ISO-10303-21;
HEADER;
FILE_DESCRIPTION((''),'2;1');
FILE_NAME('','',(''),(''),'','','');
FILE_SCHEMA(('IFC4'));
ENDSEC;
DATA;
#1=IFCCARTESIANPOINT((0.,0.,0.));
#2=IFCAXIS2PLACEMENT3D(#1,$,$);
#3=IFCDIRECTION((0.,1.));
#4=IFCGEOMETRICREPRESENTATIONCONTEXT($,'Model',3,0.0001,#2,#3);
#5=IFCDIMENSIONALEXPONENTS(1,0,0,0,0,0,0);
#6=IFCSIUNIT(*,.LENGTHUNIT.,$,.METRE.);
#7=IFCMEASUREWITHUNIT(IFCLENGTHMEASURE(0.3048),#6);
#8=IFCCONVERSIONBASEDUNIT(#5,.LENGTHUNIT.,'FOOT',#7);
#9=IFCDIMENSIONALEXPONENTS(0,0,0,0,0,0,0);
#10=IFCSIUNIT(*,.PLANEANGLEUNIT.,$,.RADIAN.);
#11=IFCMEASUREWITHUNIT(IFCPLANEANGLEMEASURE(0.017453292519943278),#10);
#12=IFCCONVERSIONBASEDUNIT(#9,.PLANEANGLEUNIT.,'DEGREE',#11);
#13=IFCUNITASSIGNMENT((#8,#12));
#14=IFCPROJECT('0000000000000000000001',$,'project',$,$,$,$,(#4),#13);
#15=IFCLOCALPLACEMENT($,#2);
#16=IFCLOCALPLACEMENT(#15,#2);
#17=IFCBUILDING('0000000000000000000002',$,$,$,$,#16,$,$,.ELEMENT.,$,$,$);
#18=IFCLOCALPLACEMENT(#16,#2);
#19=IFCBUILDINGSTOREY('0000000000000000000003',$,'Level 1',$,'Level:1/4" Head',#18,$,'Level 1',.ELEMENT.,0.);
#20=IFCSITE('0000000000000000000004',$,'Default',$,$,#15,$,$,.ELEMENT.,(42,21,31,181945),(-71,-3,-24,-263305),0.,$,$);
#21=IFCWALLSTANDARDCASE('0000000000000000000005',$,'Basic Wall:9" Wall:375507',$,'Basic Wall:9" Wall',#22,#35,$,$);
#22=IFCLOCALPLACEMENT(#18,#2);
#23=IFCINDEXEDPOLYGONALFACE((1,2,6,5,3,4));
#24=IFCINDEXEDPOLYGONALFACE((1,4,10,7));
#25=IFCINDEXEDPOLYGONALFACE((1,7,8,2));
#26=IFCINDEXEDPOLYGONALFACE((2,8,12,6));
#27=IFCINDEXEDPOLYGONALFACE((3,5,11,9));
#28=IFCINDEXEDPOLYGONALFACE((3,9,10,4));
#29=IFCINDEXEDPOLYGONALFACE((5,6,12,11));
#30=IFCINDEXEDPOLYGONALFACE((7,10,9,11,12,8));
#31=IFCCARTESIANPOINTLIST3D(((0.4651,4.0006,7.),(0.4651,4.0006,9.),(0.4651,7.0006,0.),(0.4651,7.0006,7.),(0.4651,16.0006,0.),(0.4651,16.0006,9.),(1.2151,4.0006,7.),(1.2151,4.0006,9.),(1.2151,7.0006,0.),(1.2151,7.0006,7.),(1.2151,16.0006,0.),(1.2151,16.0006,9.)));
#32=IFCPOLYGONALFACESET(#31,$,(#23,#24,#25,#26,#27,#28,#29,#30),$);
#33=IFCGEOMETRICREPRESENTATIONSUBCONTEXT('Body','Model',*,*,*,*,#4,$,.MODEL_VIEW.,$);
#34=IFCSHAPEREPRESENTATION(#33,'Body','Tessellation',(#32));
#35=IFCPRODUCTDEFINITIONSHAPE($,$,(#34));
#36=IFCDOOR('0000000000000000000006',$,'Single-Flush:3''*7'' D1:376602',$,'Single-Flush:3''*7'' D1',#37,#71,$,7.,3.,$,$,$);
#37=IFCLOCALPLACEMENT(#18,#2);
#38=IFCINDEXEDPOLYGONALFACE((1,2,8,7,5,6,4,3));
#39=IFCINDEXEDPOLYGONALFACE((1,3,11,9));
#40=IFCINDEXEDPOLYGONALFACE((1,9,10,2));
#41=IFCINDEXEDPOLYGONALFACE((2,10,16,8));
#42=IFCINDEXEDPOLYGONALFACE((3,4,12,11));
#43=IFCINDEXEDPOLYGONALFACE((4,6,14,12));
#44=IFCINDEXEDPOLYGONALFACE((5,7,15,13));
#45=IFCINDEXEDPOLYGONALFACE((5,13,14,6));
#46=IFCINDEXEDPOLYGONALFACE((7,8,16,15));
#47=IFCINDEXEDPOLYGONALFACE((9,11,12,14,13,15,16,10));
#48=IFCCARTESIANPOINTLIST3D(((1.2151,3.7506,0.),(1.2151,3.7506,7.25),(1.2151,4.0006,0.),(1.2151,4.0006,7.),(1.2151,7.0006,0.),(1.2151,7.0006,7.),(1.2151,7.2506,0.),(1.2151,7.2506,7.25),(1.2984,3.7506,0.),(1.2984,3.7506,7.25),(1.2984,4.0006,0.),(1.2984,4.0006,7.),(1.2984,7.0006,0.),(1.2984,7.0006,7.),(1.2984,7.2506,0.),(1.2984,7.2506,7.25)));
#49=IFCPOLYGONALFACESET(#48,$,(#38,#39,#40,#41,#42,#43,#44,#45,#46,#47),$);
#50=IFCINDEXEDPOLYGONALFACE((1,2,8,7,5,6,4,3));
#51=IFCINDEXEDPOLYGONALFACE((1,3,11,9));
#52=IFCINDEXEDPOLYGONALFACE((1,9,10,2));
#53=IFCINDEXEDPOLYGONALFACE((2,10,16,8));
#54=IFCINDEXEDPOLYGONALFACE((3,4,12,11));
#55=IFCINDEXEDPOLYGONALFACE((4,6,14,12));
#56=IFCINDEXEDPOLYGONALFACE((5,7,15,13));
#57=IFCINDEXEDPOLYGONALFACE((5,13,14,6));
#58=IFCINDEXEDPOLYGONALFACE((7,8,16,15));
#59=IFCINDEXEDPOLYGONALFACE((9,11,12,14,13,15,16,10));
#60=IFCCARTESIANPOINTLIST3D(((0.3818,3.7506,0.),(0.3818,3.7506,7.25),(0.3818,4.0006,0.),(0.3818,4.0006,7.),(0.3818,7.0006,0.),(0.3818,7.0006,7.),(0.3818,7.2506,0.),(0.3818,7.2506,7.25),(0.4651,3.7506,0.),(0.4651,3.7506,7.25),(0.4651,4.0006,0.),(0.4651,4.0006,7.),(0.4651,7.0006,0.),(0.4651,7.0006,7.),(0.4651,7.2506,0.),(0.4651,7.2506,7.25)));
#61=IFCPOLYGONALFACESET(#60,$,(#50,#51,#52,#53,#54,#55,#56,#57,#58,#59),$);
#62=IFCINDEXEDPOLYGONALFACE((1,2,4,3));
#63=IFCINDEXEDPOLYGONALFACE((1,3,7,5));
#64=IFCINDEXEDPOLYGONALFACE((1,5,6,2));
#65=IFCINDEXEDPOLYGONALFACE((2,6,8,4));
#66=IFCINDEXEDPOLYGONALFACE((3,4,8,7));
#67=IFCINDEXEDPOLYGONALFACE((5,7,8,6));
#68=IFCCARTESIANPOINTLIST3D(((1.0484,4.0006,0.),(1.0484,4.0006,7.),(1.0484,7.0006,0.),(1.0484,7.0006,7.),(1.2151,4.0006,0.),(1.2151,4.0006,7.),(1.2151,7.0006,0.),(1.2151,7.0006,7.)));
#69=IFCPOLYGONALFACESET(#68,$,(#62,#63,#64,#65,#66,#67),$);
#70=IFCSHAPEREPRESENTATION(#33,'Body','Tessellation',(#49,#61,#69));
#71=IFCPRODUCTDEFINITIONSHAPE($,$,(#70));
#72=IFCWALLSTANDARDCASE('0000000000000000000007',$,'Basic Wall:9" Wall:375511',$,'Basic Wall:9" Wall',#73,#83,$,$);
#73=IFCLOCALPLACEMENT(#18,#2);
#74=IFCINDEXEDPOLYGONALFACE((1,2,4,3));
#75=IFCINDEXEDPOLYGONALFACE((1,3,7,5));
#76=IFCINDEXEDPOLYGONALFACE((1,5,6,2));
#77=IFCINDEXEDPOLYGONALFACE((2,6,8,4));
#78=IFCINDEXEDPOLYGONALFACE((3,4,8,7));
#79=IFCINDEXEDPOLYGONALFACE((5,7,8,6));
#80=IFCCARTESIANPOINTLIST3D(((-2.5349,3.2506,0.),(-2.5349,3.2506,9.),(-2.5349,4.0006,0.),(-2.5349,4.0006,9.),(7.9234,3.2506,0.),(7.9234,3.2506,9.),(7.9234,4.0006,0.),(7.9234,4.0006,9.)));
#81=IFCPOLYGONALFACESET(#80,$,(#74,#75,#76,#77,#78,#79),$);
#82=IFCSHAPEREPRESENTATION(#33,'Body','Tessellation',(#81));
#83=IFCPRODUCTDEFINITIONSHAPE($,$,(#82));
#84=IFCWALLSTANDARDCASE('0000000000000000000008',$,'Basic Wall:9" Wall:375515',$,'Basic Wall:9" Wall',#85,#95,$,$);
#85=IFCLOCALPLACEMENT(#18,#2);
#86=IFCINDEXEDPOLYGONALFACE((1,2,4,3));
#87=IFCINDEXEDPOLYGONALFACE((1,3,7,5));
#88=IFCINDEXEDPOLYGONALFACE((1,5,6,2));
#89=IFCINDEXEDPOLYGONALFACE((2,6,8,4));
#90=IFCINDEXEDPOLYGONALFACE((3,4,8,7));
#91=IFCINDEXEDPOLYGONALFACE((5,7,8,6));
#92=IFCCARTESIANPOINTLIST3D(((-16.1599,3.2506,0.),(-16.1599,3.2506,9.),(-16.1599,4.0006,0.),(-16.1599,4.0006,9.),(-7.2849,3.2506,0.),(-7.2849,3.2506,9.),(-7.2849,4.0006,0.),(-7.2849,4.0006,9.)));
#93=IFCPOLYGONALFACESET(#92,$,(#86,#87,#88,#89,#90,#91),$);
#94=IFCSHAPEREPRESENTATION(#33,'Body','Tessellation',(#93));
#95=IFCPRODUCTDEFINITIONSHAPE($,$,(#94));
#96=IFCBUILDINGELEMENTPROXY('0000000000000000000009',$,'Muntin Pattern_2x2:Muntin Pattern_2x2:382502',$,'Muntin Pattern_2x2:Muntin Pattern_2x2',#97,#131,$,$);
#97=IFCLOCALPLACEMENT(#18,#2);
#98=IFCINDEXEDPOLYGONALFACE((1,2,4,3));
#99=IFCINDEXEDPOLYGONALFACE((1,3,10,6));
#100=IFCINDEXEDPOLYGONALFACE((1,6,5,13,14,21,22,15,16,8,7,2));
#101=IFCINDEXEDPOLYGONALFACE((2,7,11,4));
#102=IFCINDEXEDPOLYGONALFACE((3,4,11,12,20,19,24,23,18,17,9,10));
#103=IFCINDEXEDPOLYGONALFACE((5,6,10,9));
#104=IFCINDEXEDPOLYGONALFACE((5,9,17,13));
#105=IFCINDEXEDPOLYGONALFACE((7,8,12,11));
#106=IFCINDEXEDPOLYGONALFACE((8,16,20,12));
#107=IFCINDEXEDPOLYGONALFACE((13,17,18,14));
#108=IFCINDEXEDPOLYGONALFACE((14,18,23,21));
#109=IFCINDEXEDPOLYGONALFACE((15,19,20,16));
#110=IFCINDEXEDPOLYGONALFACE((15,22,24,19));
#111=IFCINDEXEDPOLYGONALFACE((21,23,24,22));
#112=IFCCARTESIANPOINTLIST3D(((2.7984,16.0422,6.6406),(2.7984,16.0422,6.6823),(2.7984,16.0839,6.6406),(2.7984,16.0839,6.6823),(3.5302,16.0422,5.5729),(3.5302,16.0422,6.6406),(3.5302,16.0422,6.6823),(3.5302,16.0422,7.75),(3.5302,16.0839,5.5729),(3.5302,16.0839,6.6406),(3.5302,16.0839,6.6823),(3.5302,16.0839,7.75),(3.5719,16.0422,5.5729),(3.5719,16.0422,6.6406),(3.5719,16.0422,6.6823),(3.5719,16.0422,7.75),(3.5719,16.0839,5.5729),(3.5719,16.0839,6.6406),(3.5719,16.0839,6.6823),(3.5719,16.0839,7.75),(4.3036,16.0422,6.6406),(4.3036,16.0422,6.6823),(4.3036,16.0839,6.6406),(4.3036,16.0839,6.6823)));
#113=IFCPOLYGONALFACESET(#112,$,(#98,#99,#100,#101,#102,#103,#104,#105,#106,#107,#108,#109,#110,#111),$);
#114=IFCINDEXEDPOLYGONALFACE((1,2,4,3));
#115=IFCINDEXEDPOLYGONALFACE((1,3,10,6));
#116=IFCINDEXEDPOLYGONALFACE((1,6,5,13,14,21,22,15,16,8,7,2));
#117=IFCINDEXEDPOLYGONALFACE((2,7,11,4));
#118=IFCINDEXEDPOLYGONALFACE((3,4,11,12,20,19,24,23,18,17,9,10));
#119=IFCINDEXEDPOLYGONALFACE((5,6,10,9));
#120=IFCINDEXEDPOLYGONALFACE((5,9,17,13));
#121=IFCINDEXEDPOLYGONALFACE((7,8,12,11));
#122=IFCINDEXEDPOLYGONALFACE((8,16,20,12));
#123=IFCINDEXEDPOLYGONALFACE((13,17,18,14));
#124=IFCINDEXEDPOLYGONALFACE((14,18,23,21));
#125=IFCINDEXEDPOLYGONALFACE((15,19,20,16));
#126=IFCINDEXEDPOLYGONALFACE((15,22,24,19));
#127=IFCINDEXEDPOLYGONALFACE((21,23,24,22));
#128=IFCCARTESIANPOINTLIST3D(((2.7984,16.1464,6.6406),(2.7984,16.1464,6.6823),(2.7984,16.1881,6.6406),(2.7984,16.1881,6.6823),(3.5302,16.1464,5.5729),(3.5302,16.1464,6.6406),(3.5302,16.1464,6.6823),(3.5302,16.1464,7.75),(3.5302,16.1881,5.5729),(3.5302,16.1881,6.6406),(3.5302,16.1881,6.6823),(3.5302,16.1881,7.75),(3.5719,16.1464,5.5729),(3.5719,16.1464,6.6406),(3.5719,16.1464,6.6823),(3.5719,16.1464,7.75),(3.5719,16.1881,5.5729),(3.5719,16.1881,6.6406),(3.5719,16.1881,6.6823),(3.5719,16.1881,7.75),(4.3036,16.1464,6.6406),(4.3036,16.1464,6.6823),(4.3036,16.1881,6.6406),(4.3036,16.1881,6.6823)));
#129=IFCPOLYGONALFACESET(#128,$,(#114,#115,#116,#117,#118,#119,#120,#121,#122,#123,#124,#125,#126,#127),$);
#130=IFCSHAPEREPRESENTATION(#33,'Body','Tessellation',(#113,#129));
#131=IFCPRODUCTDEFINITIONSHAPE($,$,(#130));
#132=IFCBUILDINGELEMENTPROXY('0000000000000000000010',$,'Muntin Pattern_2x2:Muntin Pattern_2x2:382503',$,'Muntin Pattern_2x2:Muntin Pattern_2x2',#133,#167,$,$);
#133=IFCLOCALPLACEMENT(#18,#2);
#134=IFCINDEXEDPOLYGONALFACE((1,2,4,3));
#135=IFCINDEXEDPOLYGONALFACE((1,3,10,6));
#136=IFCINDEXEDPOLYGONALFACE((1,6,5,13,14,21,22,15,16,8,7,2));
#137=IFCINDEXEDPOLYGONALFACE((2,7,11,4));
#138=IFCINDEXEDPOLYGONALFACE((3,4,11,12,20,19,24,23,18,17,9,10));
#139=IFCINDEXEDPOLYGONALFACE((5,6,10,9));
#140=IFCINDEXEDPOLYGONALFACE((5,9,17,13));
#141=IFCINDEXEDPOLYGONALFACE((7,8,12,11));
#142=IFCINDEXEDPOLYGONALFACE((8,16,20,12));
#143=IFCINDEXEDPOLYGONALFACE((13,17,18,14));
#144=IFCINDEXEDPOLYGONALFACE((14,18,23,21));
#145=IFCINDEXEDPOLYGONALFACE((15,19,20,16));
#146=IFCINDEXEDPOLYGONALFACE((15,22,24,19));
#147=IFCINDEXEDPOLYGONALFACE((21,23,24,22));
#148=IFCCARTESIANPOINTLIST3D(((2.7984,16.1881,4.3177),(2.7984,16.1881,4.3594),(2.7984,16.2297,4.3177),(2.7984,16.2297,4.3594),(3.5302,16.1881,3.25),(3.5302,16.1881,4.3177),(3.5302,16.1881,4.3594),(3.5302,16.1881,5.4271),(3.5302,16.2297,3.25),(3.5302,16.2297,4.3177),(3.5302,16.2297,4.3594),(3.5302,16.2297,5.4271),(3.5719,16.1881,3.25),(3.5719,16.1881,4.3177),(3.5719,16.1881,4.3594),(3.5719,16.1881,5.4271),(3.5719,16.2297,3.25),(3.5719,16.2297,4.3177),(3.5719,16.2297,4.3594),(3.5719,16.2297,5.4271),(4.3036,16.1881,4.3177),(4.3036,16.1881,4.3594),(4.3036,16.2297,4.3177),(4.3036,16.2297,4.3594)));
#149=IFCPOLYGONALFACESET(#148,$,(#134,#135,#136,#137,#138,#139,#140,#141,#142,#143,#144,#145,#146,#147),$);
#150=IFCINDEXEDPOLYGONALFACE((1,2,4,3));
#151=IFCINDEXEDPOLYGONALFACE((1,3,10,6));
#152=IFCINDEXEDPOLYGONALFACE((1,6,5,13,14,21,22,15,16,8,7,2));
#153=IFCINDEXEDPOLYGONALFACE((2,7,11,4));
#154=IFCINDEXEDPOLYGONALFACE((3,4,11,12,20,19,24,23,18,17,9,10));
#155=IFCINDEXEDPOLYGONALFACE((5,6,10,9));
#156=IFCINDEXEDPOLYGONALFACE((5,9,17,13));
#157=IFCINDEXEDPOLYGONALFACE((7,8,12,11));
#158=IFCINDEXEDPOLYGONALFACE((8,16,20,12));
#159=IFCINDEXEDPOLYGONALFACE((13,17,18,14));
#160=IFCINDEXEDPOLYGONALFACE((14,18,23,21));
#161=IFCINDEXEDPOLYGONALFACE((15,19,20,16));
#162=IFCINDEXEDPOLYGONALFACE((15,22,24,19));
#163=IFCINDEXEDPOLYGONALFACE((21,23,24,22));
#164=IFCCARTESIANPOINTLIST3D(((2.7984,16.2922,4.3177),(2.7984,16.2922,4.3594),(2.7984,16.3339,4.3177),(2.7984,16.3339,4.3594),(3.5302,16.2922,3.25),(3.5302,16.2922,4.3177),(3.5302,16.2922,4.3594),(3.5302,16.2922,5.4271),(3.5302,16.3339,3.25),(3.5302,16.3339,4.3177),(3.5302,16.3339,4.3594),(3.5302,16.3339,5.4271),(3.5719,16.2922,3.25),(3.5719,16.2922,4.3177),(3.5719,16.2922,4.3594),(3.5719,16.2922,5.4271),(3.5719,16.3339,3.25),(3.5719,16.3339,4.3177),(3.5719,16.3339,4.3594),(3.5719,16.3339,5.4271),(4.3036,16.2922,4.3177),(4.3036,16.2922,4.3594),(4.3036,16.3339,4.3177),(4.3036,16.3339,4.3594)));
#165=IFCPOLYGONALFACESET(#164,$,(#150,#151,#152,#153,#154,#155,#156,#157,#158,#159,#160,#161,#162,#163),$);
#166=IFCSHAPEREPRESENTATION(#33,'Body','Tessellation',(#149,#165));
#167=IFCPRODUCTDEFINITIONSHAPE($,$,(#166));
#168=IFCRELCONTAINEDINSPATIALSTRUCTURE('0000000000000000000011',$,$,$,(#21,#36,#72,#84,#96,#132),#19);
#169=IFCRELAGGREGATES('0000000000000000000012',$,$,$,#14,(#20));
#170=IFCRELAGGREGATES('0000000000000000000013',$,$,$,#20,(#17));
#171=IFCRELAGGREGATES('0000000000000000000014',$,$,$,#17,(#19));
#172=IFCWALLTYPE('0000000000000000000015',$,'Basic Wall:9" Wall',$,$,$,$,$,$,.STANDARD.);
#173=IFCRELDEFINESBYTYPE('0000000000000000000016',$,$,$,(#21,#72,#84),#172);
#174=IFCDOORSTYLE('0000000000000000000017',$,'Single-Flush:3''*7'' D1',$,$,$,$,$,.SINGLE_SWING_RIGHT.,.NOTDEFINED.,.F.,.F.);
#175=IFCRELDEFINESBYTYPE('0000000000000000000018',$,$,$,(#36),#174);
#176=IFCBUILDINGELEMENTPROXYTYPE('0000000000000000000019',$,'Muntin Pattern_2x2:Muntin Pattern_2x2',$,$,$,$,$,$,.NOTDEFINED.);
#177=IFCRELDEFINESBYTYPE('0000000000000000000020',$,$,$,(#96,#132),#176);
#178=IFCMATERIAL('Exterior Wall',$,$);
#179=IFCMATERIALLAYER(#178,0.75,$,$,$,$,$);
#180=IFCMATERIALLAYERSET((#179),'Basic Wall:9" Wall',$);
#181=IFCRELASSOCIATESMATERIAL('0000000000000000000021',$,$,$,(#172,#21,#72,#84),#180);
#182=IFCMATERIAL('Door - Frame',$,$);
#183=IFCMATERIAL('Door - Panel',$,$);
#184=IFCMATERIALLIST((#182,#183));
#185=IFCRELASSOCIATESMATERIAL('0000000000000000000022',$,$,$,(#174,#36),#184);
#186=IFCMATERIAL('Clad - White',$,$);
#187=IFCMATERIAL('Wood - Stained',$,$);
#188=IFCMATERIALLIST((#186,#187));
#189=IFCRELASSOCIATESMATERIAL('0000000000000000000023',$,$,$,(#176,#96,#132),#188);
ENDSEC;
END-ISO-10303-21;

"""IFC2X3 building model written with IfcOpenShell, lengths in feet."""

from ifc_helpers import new_model, entity, si_unit, converted_unit, direction, frame, frame_2d, origin, place, context, subcontext, project, spatial, polyline, rectangle, outline, extrude, clip, bounded_halfspace, source, transform, mapped, material, material_list, layer, layer_set, layer_usage, type_object, type_shapes, element, fill, save


model = new_model("IFC2X3")

# Units and contexts
model_context = context("Model", 3, precision=0.0001, world=origin(), true_north=direction((0.0, 1.0)))
body_context = subcontext(model_context, "Body", "Model", "MODEL_VIEW")
ifc_project = project(units=[converted_unit("LENGTHUNIT", "FOOT", entity("IfcLengthMeasure", 0.3048), si_unit("LENGTHUNIT", "METRE"), dimensions=[1, 0, 0, 0, 0, 0, 0]), converted_unit("PLANEANGLEUNIT", "DEGREE", entity("IfcPlaneAngleMeasure", 0.017453292519943278), si_unit("PLANEANGLEUNIT", "RADIAN"), dimensions=[0, 0, 0, 0, 0, 0, 0])], contexts=[model_context])

# Site, building, storey
site_placement = place(None, origin())
site = spatial("IfcSite", under=ifc_project, at=site_placement, Name="Default", CompositionType="ELEMENT", RefLatitude=(42, 21, 31, 181945), RefLongitude=(-71, -3, -24, -263305), RefElevation=0.0)
building_placement = place(site_placement, origin())
building = spatial("IfcBuilding", under=site, at=building_placement, CompositionType="ELEMENT")
storey_placement = place(building_placement, origin())
storey = spatial("IfcBuildingStorey", under=building, at=storey_placement, Name="Level 1", ObjectType="Level:1/4\" Head", LongName="Level 1", CompositionType="ELEMENT", Elevation=0.0)

# Shared definitions
ifc_material_1 = material(Name="Exterior Wall")
ifc_layer = layer(ifc_material_1, 0.75)
ifc_layer_set = layer_set([ifc_layer], Name="Basic Wall:9\" Wall")
ifc_layer_usage = layer_usage(ifc_layer_set, "AXIS2", "NEGATIVE", 0.375)
wall_type = type_object("IfcWallType", Name="Basic Wall:9\" Wall", PredefinedType="STANDARD", material=ifc_layer_set)

# Shared definitions
ifc_material_2 = material(Name="Wood - Stained")

# Wall, opening, door
wall_1_placement = place(storey_placement, frame((0.8401, 16.0006, 0.0), z_axis=(0.0, 0.0, 1.0), x_axis=(0.0, -1.0, 0.0)))
wall_1 = element("IfcWallStandardCase", 1, at=wall_1_placement, inside=storey, type_object=wall_type, material=ifc_layer_usage, Name="Basic Wall:9\" Wall:375507", ObjectType="Basic Wall:9\" Wall", context=body_context, shape_type="Clipping", body=[
    clip(extrude(rectangle(XDim=12.0, YDim=0.75, at=frame_2d((6.0, 0.0), x_axis=(-1.0, 0.0))), origin(), (0.0, 0.0, 1.0), 9.0), bounded_halfspace(frame((12.0, 0.375, 9.0), z_axis=(0.0, 0.0, -1.0), x_axis=(1.0, 0.0, 0.0)), True, frame((12.0, 0.375, 9.0)), polyline([(0.0, 0.0), (-12.0, 0.0), (-12.0, -0.75), (-3.1667, -0.75), (0.0, -0.75), (0.0, 0.0)]))),
])
opening_1_placement = place(wall_1_placement, frame((9.0, -0.375, 0.0)))
opening_1 = element("IfcOpeningElement", 2, at=opening_1_placement, cuts=wall_1, ObjectType="Opening", context=body_context, shape_type="SweptSolid", body=[
    extrude(rectangle(XDim=3.0, YDim=7.0, at=frame_2d((3.5, 1.5), x_axis=(0.0, 1.0))), frame((0.0, 0.0, 0.0), z_axis=(0.0, 1.0, 0.0), x_axis=(0.0, 0.0, 1.0)), (0.0, 0.0, 1.0), 0.75),
])
ifc_material_3 = material(Name="Door - Frame")
ifc_material_4 = material(Name="Door - Panel")
ifc_material_list_1 = material_list([ifc_material_3, ifc_material_4])
door_style = type_object("IfcDoorStyle", Name="Single-Flush:3'*7' D1", ConstructionType="NOTDEFINED", OperationType="SINGLE_SWING_RIGHT", ParameterTakesPrecedence=False, Sizeable=False, material=ifc_material_list_1)
shared_shape_1 = source(origin(), body_context, "Body", "SweptSolid", [
    extrude(outline(polyline([(-1.75, -3.6875), (1.75, -3.6875), (1.75, 3.5625), (1.5, 3.5625), (1.5, -3.4375), (-1.5, -3.4375), (-1.5, 3.5625), (-1.75, 3.5625), (-1.75, -3.6875)])), frame((1.5, 0.75, 3.5625), z_axis=(0.0, 1.0, 0.0), x_axis=(1.0, 0.0, 0.0)), (0.0, 0.0, 1.0), 0.0833),
    extrude(outline(polyline([(-3.6875, -1.75), (3.5625, -1.75), (3.5625, -1.5), (-3.4375, -1.5), (-3.4375, 1.5), (3.5625, 1.5), (3.5625, 1.75), (-3.6875, 1.75), (-3.6875, -1.75)])), frame((1.5, -0.0833, 3.5625), z_axis=(0.0, 1.0, 0.0), x_axis=(0.0, 0.0, -1.0)), (0.0, 0.0, 1.0), 0.0833),
    extrude(rectangle(XDim=0.1667, YDim=3.0, at=frame_2d((0.0, 0.0), x_axis=(1.0, 0.0))), frame((1.5, 0.6667, 0.0), z_axis=(0.0, 0.0, 1.0), x_axis=(0.0, 1.0, 0.0)), (0.0, 0.0, 1.0), 7.0),
])
type_shapes(door_style, [shared_shape_1])
door_placement = place(opening_1_placement, origin())
door = element("IfcDoor", 3, at=door_placement, inside=storey, type_object=door_style, material=ifc_material_list_1, Name="Single-Flush:3'*7' D1:376602", ObjectType="Single-Flush:3'*7' D1", OverallHeight=7.0, OverallWidth=3.0, context=body_context, shape_type="MappedRepresentation", body=[
    mapped(shared_shape_1, transform((0.0, 0.0, 0.0), scale=1.0)),
])
fill(opening_1, door)

# Wall, opening
wall_2_placement = place(storey_placement, frame((-2.5349, 3.6256, 0.0)))
wall_2 = element("IfcWallStandardCase", 4, at=wall_2_placement, inside=storey, type_object=wall_type, material=ifc_layer_usage, Name="Basic Wall:9\" Wall:375511", ObjectType="Basic Wall:9\" Wall", context=body_context, shape_type="Clipping", body=[
    clip(extrude(rectangle(XDim=10.4583, YDim=0.75, at=frame_2d((5.2292, 0.0), x_axis=(-1.0, 0.0))), origin(), (0.0, 0.0, 1.0), 9.0), bounded_halfspace(frame((0.0, -0.375, 9.0), z_axis=(0.0, 0.0, -1.0), x_axis=(0.0, -1.0, 0.0)), True, frame((0.0, -0.375, 9.0)), polyline([(0.0, 0.0), (0.75, 0.0), (10.4583, 0.0), (10.4583, 0.75), (3.75, 0.75), (3.0, 0.75), (0.0, 0.75), (0.0, 0.0)]))),
])
opening_2_placement = place(wall_2_placement, origin())
element("IfcOpeningElement", 5, at=opening_2_placement, cuts=wall_2, ObjectType="Opening", context=body_context, shape_type="SweptSolid", body=[
    extrude(rectangle(XDim=7.0, YDim=0.75, at=frame_2d((0.0, 0.0), x_axis=(0.0, 1.0))), frame((3.375, 0.375, 3.5), z_axis=(0.0, 1.0, 0.0), x_axis=(1.0, 0.0, 0.0)), (0.0, 0.0, 1.0), 3.0),
])

# Wall
wall_3_placement = place(storey_placement, frame((-16.1599, 3.6256, 0.0)))
element("IfcWallStandardCase", 6, at=wall_3_placement, inside=storey, type_object=wall_type, material=ifc_layer_usage, Name="Basic Wall:9\" Wall:375515", ObjectType="Basic Wall:9\" Wall", context=body_context, shape_type="Clipping", body=[
    clip(extrude(rectangle(XDim=8.875, YDim=0.75, at=frame_2d((4.4375, 0.0), x_axis=(-1.0, 0.0))), origin(), (0.0, 0.0, 1.0), 9.0), bounded_halfspace(frame((0.0, -0.375, 9.0), z_axis=(0.0, 0.0, -1.0), x_axis=(0.0, -1.0, 0.0)), True, frame((0.0, -0.375, 9.0)), polyline([(0.0, 0.0), (8.875, 0.0), (8.875, 0.75), (0.0, 0.75), (0.0, 0.0)]))),
])

# Building element proxies
ifc_material_5 = material(Name="Clad - White")
ifc_material_list_2 = material_list([ifc_material_5, ifc_material_2])
building_element_proxy_type_1 = type_object("IfcBuildingElementProxyType", Name="Muntin Pattern_2x2:Muntin Pattern_2x2", PredefinedType="NOTDEFINED", material=ifc_material_list_2)
shared_shape_2 = source(origin(), body_context, "Body", "SweptSolid", [
    extrude(outline(polyline([(0.0208, -0.0208), (1.0885, -0.0208), (1.0885, 0.0208), (0.0208, 0.0208), (0.0208, 0.7526), (-0.0208, 0.7526), (-0.0208, 0.0208), (-1.0885, 0.0208), (-1.0885, -0.0208), (-0.0208, -0.0208), (-0.0208, -0.7526), (0.0208, -0.7526), (0.0208, -0.0208)])), frame((0.0, 0.0312, 1.0885), z_axis=(0.0, 1.0, 0.0), x_axis=(0.0, 0.0, 1.0)), (0.0, 0.0, 1.0), 0.0417),
    extrude(outline(polyline([(0.0208, -0.0208), (1.0885, -0.0208), (1.0885, 0.0208), (0.0208, 0.0208), (0.0208, 0.7526), (-0.0208, 0.7526), (-0.0208, 0.0208), (-1.0885, 0.0208), (-1.0885, -0.0208), (-0.0208, -0.0208), (-0.0208, -0.7526), (0.0208, -0.7526), (0.0208, -0.0208)])), frame((0.0, -0.0729, 1.0885), z_axis=(0.0, 1.0, 0.0), x_axis=(0.0, 0.0, 1.0)), (0.0, 0.0, 1.0), 0.0417),
])
type_shapes(building_element_proxy_type_1, [shared_shape_2])
for number, where, z_axis, x_axis, name in (
    (7, (3.551, 16.1152, 5.5729), (0.0, 0.0, 1.0), (-1.0, 0.0, 0.0), "Muntin Pattern_2x2:Muntin Pattern_2x2:382502"),
    (8, (3.551, 16.261, 3.25), (0.0, 0.0, 1.0), (-1.0, 0.0, 0.0), "Muntin Pattern_2x2:Muntin Pattern_2x2:382503"),
):
    element("IfcBuildingElementProxy", number, at=place(storey_placement, frame(where, z_axis=z_axis, x_axis=x_axis)), inside=storey, type_object=building_element_proxy_type_1, material=ifc_material_list_2, Name=name, ObjectType="Muntin Pattern_2x2:Muntin Pattern_2x2", context=body_context, shape_type="MappedRepresentation", body=[
        mapped(shared_shape_2, transform((0.0, 0.0, 0.0), scale=1.0)),
    ])

save(model, "model.ifc")
